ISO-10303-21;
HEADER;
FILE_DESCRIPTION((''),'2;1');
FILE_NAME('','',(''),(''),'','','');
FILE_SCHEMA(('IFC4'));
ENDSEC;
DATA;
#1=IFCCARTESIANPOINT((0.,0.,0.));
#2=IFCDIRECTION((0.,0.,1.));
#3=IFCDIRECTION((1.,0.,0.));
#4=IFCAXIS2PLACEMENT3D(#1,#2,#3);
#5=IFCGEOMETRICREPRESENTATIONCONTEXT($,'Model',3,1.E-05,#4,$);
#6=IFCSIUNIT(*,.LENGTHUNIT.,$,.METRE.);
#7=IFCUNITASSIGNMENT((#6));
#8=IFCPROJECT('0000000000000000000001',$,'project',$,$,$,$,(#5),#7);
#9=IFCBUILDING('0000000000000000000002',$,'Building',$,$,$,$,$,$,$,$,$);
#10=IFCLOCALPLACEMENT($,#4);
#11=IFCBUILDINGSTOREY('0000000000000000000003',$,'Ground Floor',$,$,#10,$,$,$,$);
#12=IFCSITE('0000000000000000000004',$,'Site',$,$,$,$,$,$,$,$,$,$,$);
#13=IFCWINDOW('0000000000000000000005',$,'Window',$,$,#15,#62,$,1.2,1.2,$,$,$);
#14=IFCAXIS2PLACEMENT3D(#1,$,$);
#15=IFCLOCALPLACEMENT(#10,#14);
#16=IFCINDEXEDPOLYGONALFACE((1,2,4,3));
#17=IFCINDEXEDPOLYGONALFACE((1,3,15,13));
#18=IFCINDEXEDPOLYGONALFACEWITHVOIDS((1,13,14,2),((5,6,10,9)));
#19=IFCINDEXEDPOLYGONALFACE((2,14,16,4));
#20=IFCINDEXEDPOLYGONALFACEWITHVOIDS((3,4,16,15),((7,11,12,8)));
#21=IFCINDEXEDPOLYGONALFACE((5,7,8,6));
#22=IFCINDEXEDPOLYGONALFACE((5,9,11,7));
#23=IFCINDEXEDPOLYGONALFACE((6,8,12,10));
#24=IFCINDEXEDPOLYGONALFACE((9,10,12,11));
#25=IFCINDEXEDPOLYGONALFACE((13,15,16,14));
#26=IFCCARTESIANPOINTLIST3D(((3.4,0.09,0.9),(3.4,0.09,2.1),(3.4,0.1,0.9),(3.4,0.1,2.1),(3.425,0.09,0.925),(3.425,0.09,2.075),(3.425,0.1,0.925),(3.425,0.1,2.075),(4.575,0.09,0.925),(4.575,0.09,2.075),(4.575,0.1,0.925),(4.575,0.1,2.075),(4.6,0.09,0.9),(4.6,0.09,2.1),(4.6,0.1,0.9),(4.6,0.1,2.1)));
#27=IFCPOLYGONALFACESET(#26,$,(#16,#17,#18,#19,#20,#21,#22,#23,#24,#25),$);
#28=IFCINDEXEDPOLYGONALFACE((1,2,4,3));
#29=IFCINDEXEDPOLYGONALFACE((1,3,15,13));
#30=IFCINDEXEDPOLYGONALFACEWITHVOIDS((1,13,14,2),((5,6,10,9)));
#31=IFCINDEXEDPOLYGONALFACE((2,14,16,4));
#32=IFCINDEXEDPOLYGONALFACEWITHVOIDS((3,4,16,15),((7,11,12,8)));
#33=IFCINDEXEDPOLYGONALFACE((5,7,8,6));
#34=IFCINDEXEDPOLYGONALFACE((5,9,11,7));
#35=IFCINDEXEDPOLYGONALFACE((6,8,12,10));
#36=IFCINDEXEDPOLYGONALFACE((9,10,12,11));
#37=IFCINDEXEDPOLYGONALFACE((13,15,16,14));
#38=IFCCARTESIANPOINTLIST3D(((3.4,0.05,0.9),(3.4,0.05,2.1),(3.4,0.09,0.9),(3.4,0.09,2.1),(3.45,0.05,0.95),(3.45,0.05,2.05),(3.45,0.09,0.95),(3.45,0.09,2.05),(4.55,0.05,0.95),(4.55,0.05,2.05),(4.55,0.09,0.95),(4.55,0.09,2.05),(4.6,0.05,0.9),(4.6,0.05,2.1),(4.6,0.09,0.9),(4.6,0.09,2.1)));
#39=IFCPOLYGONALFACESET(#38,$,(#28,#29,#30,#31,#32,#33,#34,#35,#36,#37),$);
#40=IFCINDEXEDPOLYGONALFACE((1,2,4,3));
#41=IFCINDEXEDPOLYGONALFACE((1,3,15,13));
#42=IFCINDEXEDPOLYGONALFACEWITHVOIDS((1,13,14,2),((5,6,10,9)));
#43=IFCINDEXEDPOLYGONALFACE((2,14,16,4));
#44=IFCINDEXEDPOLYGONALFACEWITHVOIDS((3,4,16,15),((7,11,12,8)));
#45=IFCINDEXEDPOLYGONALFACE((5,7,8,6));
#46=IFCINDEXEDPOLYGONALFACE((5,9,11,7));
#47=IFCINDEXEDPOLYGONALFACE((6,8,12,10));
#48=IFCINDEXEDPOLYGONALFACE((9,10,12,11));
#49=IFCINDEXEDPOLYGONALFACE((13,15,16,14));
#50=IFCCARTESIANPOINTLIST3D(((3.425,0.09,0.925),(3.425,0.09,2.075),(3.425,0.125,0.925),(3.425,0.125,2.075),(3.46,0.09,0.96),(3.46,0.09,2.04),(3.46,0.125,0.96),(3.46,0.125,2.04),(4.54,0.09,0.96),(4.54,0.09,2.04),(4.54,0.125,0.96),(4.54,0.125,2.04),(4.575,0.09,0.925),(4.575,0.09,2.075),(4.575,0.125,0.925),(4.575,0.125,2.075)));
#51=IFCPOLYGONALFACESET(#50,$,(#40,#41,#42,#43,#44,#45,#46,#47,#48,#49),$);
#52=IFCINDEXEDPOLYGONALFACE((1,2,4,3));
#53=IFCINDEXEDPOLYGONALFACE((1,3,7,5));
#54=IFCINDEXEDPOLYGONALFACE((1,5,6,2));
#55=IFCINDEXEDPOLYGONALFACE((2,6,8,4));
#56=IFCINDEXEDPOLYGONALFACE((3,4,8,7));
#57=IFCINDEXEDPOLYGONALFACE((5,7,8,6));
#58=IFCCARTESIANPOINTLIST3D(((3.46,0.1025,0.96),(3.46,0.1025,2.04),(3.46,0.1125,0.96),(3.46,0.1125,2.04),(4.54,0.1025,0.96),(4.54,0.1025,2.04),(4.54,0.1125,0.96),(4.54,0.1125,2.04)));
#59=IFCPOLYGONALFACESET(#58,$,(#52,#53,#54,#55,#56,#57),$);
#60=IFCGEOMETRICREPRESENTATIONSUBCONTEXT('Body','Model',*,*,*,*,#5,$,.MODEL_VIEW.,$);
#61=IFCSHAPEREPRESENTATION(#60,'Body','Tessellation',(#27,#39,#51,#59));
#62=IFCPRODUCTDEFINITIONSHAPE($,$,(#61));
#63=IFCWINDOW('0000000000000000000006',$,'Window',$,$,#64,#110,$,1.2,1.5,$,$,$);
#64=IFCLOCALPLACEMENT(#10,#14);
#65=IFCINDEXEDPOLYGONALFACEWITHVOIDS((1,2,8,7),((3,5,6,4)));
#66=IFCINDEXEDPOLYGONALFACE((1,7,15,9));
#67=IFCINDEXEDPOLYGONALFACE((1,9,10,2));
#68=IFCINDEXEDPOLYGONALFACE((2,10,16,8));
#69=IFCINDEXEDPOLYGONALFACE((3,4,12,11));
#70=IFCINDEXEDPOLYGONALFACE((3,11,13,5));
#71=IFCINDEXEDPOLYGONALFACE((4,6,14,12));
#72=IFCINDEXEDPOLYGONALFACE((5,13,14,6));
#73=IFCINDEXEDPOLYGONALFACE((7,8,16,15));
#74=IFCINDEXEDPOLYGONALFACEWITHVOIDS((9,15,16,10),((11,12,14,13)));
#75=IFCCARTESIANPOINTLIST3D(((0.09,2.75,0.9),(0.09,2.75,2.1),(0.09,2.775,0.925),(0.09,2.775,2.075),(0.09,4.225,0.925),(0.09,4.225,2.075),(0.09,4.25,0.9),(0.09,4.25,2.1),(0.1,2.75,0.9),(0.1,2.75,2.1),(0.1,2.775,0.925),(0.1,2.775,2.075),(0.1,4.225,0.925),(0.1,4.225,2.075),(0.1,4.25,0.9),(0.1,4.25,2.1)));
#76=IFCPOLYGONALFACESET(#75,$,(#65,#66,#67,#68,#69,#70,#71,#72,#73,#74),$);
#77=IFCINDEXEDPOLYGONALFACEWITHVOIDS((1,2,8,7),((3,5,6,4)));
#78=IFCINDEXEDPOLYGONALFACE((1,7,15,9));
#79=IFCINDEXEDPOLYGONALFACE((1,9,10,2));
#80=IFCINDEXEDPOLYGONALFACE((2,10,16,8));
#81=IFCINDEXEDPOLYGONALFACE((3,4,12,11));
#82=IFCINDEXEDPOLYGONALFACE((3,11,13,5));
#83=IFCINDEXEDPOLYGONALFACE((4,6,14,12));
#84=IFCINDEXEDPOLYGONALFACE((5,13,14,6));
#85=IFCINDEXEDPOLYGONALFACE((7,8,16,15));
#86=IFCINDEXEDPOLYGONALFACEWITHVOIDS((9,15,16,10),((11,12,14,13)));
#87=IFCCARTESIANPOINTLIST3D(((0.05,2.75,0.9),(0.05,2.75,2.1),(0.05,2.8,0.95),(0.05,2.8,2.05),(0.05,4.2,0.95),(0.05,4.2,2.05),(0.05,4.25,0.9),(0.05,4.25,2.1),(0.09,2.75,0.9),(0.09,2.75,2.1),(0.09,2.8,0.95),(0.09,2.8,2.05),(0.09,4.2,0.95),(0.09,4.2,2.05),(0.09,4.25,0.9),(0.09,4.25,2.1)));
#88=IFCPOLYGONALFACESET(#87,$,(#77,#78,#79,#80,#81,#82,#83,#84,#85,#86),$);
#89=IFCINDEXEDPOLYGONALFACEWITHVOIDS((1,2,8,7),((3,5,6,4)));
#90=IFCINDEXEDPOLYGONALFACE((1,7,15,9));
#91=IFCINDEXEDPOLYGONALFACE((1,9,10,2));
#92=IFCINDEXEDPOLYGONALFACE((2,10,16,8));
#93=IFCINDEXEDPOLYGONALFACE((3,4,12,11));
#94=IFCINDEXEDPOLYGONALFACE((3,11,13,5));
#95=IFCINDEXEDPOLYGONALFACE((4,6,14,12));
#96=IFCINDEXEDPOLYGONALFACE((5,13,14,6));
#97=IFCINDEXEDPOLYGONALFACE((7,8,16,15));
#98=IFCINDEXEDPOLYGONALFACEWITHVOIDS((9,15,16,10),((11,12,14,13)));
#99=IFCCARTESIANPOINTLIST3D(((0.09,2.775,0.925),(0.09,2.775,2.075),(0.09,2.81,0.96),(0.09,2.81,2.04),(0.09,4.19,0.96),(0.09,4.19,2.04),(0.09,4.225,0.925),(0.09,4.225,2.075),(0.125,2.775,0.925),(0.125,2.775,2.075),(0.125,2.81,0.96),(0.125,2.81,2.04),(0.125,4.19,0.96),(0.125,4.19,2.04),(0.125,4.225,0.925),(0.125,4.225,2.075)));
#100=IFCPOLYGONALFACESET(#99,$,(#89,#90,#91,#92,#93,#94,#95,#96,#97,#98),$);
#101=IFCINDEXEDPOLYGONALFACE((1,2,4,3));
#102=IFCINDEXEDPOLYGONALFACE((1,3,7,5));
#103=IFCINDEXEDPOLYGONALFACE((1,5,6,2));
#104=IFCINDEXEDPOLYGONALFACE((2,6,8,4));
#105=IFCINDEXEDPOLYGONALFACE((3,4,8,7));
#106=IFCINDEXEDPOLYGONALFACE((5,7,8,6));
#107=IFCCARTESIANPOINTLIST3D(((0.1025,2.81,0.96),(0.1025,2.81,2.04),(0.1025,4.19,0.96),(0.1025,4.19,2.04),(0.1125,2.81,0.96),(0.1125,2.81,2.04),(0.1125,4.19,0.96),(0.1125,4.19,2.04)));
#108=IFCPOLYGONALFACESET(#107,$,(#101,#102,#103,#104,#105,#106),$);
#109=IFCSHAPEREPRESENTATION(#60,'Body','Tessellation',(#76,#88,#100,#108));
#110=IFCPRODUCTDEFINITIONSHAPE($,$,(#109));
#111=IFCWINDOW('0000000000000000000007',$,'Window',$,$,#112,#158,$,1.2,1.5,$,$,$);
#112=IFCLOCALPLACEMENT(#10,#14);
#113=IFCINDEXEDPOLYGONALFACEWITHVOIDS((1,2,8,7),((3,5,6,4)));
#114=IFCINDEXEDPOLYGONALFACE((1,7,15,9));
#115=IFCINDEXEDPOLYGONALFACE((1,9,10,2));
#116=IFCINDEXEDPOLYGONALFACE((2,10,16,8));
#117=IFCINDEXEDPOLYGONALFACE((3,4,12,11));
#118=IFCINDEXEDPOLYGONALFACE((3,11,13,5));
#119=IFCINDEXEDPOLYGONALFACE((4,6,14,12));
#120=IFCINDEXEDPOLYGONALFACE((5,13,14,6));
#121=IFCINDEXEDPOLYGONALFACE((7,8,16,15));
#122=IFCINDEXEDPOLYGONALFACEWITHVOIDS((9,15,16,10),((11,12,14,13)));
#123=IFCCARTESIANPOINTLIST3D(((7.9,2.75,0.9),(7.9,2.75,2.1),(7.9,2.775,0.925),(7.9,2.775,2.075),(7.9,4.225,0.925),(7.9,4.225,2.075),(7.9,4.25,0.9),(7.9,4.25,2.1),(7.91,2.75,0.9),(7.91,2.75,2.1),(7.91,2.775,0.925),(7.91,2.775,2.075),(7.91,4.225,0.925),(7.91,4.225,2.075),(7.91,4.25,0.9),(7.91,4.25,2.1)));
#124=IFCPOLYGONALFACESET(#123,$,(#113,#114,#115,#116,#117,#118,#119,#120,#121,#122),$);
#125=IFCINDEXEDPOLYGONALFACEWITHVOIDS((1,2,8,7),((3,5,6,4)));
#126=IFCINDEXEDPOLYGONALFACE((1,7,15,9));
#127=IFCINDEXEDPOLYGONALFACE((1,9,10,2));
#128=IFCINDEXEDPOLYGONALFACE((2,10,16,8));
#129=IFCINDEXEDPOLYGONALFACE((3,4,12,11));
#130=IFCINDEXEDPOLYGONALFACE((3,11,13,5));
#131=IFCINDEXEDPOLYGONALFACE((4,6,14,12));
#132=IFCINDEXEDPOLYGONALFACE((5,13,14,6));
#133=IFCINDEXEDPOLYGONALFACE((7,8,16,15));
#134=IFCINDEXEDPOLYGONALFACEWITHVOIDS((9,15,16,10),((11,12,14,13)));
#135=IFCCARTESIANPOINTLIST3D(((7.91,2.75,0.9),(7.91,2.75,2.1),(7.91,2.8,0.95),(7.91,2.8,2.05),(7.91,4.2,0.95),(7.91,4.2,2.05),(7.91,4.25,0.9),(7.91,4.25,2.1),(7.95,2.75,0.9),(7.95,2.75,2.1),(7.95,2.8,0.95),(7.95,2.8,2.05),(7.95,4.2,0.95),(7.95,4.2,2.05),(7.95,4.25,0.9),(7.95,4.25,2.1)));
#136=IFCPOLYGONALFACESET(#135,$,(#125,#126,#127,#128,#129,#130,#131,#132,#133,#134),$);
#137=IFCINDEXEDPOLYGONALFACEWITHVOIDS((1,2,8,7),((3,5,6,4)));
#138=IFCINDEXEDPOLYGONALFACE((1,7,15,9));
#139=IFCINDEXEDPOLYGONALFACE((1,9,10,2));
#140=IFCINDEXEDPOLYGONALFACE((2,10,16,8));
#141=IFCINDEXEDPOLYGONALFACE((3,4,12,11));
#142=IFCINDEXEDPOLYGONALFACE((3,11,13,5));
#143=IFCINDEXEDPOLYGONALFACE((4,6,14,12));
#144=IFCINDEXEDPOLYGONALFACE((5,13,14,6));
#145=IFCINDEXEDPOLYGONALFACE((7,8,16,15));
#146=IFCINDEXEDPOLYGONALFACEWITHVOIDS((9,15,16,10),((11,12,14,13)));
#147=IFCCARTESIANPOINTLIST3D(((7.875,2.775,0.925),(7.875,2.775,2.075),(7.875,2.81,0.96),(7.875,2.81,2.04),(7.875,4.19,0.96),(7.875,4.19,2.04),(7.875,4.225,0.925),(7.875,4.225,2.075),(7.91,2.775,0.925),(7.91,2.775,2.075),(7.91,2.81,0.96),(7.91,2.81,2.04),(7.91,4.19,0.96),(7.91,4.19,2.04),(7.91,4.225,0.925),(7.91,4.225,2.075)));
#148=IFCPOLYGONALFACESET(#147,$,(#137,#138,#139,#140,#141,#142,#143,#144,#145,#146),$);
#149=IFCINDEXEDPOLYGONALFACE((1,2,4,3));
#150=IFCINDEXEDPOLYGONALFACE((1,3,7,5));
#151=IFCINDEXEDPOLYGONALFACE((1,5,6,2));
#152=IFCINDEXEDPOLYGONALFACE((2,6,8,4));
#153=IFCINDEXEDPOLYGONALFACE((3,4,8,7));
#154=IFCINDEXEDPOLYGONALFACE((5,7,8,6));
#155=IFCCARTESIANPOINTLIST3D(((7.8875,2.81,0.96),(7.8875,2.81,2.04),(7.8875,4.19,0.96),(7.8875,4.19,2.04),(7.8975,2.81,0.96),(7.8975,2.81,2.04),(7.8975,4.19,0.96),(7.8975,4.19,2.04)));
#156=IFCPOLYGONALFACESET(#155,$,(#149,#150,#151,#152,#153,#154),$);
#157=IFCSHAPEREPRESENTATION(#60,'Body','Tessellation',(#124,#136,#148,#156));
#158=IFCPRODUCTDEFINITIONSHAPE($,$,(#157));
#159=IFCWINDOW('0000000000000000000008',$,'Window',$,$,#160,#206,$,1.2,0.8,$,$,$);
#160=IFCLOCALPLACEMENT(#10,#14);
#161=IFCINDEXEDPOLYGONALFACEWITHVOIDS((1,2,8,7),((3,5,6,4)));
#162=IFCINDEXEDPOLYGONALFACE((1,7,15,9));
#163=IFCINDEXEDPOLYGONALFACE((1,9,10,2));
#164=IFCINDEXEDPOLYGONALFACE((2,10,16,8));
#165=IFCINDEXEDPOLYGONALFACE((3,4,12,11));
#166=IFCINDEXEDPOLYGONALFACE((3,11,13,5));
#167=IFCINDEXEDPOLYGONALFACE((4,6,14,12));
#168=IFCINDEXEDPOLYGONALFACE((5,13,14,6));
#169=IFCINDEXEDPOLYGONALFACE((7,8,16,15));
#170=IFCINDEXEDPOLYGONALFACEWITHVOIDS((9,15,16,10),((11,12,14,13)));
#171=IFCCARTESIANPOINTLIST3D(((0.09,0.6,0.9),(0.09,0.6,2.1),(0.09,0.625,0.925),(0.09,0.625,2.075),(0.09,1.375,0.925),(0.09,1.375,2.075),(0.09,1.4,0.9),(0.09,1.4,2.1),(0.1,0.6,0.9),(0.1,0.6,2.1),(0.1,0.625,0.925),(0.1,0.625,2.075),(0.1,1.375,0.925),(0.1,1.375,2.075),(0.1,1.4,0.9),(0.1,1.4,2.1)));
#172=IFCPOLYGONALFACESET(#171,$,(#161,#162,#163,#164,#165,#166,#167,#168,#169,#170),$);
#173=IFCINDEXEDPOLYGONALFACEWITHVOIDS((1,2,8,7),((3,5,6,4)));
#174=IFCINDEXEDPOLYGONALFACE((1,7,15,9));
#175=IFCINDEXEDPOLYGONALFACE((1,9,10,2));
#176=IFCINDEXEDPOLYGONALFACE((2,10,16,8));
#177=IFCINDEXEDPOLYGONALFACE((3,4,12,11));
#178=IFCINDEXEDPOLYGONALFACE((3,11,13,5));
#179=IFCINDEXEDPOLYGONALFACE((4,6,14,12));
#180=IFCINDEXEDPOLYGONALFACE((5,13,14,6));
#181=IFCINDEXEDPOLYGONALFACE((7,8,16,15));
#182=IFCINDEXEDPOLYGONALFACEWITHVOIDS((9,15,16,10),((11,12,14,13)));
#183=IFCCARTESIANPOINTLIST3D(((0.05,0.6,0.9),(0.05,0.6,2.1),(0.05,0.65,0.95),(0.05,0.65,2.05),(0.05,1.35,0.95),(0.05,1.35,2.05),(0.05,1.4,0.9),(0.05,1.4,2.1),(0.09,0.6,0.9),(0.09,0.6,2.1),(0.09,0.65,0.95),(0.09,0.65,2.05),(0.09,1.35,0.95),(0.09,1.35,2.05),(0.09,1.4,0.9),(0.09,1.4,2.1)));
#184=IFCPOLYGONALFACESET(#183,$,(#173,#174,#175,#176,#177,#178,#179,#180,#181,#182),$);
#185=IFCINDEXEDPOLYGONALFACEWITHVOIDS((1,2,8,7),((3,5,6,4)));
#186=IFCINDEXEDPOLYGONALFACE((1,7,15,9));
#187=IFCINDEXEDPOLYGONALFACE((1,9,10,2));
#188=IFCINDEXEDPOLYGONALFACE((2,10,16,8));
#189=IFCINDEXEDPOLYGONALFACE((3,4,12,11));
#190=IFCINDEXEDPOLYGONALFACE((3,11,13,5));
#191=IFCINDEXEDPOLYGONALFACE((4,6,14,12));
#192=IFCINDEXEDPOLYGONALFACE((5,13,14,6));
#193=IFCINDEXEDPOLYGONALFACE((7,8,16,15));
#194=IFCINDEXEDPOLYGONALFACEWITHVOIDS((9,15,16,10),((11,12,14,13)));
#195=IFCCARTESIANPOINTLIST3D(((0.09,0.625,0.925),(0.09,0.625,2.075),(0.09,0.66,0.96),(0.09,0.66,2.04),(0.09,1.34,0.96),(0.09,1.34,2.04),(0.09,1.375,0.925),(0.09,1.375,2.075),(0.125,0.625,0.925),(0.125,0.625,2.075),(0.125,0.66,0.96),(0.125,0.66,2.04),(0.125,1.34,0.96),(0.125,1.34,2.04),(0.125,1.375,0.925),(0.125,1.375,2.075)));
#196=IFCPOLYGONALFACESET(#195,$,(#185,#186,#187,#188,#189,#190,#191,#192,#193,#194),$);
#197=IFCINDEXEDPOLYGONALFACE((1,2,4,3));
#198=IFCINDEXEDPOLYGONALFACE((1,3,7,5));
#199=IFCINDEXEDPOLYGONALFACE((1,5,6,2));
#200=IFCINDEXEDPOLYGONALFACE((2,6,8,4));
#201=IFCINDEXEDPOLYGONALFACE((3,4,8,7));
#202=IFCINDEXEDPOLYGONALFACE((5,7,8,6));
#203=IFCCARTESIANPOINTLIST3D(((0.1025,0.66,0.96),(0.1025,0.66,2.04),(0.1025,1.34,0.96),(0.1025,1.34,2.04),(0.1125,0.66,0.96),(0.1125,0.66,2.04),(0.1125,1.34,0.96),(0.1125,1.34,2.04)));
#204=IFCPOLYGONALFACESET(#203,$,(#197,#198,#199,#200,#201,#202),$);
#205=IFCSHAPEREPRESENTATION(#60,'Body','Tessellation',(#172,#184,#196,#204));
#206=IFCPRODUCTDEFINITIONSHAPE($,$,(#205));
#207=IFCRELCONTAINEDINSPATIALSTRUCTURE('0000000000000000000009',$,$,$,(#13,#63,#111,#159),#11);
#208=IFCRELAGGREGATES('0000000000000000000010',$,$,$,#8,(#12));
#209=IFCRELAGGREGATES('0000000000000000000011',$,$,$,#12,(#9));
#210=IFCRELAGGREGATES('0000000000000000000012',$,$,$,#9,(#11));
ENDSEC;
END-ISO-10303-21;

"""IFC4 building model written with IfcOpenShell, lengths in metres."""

from ifc_helpers import new_model, si_unit, frame, origin_with_axes, place, context, subcontext, project, spatial, line, indexed_curve, outline, extrude, element, save


model = new_model("IFC4")

# Units and contexts
model_context = context("Model", 3, precision=1e-05, world=origin_with_axes())
body_context = subcontext(model_context, "Body", "Model", "MODEL_VIEW")
ifc_project = project(units=[si_unit("LENGTHUNIT", "METRE")], contexts=[model_context])

# Site, building, storey
site = spatial("IfcSite", under=ifc_project, Name="Site")
building = spatial("IfcBuilding", under=site, Name="Building")
storey_placement = place(None, origin_with_axes())
storey = spatial("IfcBuildingStorey", under=building, at=storey_placement, Name="Ground Floor")

# Windows
window_1_placement = place(storey_placement, frame((3.4, 0.0, 0.9), z_axis=(0.0, 0.0, 1.0), x_axis=(1.0, 0.0, 0.0)))
element("IfcWindow", 1, at=window_1_placement, inside=storey, Name="Window", OverallHeight=1.2, OverallWidth=1.2, context=body_context, shape_type="SweptSolid", body=[
    extrude(outline(indexed_curve([(0.0, 0.0), (1.2, 0.0), (1.2, 1.2), (0.0, 1.2)], segments=[line(1, 2, 3, 4, 1)]), holes=[indexed_curve([(0.025, 0.025), (1.175, 0.025), (1.175, 1.175), (0.025, 1.175)], segments=[line(1, 2, 3, 4, 1)])]), frame((0.0, 0.09, 0.0), z_axis=(0.0, -1.0, 0.0), x_axis=(1.0, 0.0, 0.0)), (0.0, 0.0, -1.0), 0.01),
    extrude(outline(indexed_curve([(0.0, 0.0), (1.2, 0.0), (1.2, 1.2), (0.0, 1.2)], segments=[line(1, 2, 3, 4, 1)]), holes=[indexed_curve([(0.05, 0.05), (1.15, 0.05), (1.15, 1.15), (0.05, 1.15)], segments=[line(1, 2, 3, 4, 1)])]), frame((0.0, 0.05, 0.0), z_axis=(0.0, -1.0, 0.0), x_axis=(1.0, 0.0, 0.0)), (0.0, 0.0, -1.0), 0.04),
    extrude(outline(indexed_curve([(0.0, 0.0), (1.15, 0.0), (1.15, 1.15), (0.0, 1.15)], segments=[line(1, 2, 3, 4, 1)]), holes=[indexed_curve([(0.035, 0.035), (1.115, 0.035), (1.115, 1.115), (0.035, 1.115)], segments=[line(1, 2, 3, 4, 1)])]), frame((0.025, 0.09, 0.025), z_axis=(0.0, -1.0, 0.0), x_axis=(1.0, 0.0, 0.0)), (0.0, 0.0, -1.0), 0.035),
    extrude(outline(indexed_curve([(0.035, 0.035), (1.115, 0.035), (1.115, 1.115), (0.035, 1.115)], segments=[line(1, 2, 3, 4, 1)])), frame((0.025, 0.1025, 0.025), z_axis=(0.0, -1.0, 0.0), x_axis=(1.0, 0.0, 0.0)), (0.0, 0.0, -1.0), 0.01),
])
for number, where, z_axis, x_axis, name in (
    (2, (0.0, 4.25, 0.9), (0.0, 0.0, 1.0), (0.0, -1.0, 0.0), "Window"),
    (3, (8.0, 2.75, 0.9), (0.0, 0.0, 1.0), (0.0, 1.0, 0.0), "Window"),
):
    element("IfcWindow", number, at=place(storey_placement, frame(where, z_axis=z_axis, x_axis=x_axis)), inside=storey, Name=name, OverallHeight=1.2, OverallWidth=1.5, context=body_context, shape_type="SweptSolid", body=[
        extrude(outline(indexed_curve([(0.0, 0.0), (1.5, 0.0), (1.5, 1.2), (0.0, 1.2)], segments=[line(1, 2, 3, 4, 1)]), holes=[indexed_curve([(0.025, 0.025), (1.475, 0.025), (1.475, 1.175), (0.025, 1.175)], segments=[line(1, 2, 3, 4, 1)])]), frame((0.0, 0.09, 0.0), z_axis=(0.0, -1.0, 0.0), x_axis=(1.0, 0.0, 0.0)), (0.0, 0.0, -1.0), 0.01),
        extrude(outline(indexed_curve([(0.0, 0.0), (1.5, 0.0), (1.5, 1.2), (0.0, 1.2)], segments=[line(1, 2, 3, 4, 1)]), holes=[indexed_curve([(0.05, 0.05), (1.45, 0.05), (1.45, 1.15), (0.05, 1.15)], segments=[line(1, 2, 3, 4, 1)])]), frame((0.0, 0.05, 0.0), z_axis=(0.0, -1.0, 0.0), x_axis=(1.0, 0.0, 0.0)), (0.0, 0.0, -1.0), 0.04),
        extrude(outline(indexed_curve([(0.0, 0.0), (1.45, 0.0), (1.45, 1.15), (0.0, 1.15)], segments=[line(1, 2, 3, 4, 1)]), holes=[indexed_curve([(0.035, 0.035), (1.415, 0.035), (1.415, 1.115), (0.035, 1.115)], segments=[line(1, 2, 3, 4, 1)])]), frame((0.025, 0.09, 0.025), z_axis=(0.0, -1.0, 0.0), x_axis=(1.0, 0.0, 0.0)), (0.0, 0.0, -1.0), 0.035),
        extrude(outline(indexed_curve([(0.035, 0.035), (1.415, 0.035), (1.415, 1.115), (0.035, 1.115)], segments=[line(1, 2, 3, 4, 1)])), frame((0.025, 0.1025, 0.025), z_axis=(0.0, -1.0, 0.0), x_axis=(1.0, 0.0, 0.0)), (0.0, 0.0, -1.0), 0.01),
    ])
window_2_placement = place(storey_placement, frame((0.0, 1.4, 0.9), z_axis=(0.0, 0.0, 1.0), x_axis=(0.0, -1.0, 0.0)))
element("IfcWindow", 4, at=window_2_placement, inside=storey, Name="Window", OverallHeight=1.2, OverallWidth=0.8, context=body_context, shape_type="SweptSolid", body=[
    extrude(outline(indexed_curve([(0.0, 0.0), (0.8, 0.0), (0.8, 1.2), (0.0, 1.2)], segments=[line(1, 2, 3, 4, 1)]), holes=[indexed_curve([(0.025, 0.025), (0.775, 0.025), (0.775, 1.175), (0.025, 1.175)], segments=[line(1, 2, 3, 4, 1)])]), frame((0.0, 0.09, 0.0), z_axis=(0.0, -1.0, 0.0), x_axis=(1.0, 0.0, 0.0)), (0.0, 0.0, -1.0), 0.01),
    extrude(outline(indexed_curve([(0.0, 0.0), (0.8, 0.0), (0.8, 1.2), (0.0, 1.2)], segments=[line(1, 2, 3, 4, 1)]), holes=[indexed_curve([(0.05, 0.05), (0.75, 0.05), (0.75, 1.15), (0.05, 1.15)], segments=[line(1, 2, 3, 4, 1)])]), frame((0.0, 0.05, 0.0), z_axis=(0.0, -1.0, 0.0), x_axis=(1.0, 0.0, 0.0)), (0.0, 0.0, -1.0), 0.04),
    extrude(outline(indexed_curve([(0.0, 0.0), (0.75, 0.0), (0.75, 1.15), (0.0, 1.15)], segments=[line(1, 2, 3, 4, 1)]), holes=[indexed_curve([(0.035, 0.035), (0.715, 0.035), (0.715, 1.115), (0.035, 1.115)], segments=[line(1, 2, 3, 4, 1)])]), frame((0.025, 0.09, 0.025), z_axis=(0.0, -1.0, 0.0), x_axis=(1.0, 0.0, 0.0)), (0.0, 0.0, -1.0), 0.035),
    extrude(outline(indexed_curve([(0.035, 0.035), (0.715, 0.035), (0.715, 1.115), (0.035, 1.115)], segments=[line(1, 2, 3, 4, 1)])), frame((0.025, 0.1025, 0.025), z_axis=(0.0, -1.0, 0.0), x_axis=(1.0, 0.0, 0.0)), (0.0, 0.0, -1.0), 0.01),
])

save(model, "model.ifc")
